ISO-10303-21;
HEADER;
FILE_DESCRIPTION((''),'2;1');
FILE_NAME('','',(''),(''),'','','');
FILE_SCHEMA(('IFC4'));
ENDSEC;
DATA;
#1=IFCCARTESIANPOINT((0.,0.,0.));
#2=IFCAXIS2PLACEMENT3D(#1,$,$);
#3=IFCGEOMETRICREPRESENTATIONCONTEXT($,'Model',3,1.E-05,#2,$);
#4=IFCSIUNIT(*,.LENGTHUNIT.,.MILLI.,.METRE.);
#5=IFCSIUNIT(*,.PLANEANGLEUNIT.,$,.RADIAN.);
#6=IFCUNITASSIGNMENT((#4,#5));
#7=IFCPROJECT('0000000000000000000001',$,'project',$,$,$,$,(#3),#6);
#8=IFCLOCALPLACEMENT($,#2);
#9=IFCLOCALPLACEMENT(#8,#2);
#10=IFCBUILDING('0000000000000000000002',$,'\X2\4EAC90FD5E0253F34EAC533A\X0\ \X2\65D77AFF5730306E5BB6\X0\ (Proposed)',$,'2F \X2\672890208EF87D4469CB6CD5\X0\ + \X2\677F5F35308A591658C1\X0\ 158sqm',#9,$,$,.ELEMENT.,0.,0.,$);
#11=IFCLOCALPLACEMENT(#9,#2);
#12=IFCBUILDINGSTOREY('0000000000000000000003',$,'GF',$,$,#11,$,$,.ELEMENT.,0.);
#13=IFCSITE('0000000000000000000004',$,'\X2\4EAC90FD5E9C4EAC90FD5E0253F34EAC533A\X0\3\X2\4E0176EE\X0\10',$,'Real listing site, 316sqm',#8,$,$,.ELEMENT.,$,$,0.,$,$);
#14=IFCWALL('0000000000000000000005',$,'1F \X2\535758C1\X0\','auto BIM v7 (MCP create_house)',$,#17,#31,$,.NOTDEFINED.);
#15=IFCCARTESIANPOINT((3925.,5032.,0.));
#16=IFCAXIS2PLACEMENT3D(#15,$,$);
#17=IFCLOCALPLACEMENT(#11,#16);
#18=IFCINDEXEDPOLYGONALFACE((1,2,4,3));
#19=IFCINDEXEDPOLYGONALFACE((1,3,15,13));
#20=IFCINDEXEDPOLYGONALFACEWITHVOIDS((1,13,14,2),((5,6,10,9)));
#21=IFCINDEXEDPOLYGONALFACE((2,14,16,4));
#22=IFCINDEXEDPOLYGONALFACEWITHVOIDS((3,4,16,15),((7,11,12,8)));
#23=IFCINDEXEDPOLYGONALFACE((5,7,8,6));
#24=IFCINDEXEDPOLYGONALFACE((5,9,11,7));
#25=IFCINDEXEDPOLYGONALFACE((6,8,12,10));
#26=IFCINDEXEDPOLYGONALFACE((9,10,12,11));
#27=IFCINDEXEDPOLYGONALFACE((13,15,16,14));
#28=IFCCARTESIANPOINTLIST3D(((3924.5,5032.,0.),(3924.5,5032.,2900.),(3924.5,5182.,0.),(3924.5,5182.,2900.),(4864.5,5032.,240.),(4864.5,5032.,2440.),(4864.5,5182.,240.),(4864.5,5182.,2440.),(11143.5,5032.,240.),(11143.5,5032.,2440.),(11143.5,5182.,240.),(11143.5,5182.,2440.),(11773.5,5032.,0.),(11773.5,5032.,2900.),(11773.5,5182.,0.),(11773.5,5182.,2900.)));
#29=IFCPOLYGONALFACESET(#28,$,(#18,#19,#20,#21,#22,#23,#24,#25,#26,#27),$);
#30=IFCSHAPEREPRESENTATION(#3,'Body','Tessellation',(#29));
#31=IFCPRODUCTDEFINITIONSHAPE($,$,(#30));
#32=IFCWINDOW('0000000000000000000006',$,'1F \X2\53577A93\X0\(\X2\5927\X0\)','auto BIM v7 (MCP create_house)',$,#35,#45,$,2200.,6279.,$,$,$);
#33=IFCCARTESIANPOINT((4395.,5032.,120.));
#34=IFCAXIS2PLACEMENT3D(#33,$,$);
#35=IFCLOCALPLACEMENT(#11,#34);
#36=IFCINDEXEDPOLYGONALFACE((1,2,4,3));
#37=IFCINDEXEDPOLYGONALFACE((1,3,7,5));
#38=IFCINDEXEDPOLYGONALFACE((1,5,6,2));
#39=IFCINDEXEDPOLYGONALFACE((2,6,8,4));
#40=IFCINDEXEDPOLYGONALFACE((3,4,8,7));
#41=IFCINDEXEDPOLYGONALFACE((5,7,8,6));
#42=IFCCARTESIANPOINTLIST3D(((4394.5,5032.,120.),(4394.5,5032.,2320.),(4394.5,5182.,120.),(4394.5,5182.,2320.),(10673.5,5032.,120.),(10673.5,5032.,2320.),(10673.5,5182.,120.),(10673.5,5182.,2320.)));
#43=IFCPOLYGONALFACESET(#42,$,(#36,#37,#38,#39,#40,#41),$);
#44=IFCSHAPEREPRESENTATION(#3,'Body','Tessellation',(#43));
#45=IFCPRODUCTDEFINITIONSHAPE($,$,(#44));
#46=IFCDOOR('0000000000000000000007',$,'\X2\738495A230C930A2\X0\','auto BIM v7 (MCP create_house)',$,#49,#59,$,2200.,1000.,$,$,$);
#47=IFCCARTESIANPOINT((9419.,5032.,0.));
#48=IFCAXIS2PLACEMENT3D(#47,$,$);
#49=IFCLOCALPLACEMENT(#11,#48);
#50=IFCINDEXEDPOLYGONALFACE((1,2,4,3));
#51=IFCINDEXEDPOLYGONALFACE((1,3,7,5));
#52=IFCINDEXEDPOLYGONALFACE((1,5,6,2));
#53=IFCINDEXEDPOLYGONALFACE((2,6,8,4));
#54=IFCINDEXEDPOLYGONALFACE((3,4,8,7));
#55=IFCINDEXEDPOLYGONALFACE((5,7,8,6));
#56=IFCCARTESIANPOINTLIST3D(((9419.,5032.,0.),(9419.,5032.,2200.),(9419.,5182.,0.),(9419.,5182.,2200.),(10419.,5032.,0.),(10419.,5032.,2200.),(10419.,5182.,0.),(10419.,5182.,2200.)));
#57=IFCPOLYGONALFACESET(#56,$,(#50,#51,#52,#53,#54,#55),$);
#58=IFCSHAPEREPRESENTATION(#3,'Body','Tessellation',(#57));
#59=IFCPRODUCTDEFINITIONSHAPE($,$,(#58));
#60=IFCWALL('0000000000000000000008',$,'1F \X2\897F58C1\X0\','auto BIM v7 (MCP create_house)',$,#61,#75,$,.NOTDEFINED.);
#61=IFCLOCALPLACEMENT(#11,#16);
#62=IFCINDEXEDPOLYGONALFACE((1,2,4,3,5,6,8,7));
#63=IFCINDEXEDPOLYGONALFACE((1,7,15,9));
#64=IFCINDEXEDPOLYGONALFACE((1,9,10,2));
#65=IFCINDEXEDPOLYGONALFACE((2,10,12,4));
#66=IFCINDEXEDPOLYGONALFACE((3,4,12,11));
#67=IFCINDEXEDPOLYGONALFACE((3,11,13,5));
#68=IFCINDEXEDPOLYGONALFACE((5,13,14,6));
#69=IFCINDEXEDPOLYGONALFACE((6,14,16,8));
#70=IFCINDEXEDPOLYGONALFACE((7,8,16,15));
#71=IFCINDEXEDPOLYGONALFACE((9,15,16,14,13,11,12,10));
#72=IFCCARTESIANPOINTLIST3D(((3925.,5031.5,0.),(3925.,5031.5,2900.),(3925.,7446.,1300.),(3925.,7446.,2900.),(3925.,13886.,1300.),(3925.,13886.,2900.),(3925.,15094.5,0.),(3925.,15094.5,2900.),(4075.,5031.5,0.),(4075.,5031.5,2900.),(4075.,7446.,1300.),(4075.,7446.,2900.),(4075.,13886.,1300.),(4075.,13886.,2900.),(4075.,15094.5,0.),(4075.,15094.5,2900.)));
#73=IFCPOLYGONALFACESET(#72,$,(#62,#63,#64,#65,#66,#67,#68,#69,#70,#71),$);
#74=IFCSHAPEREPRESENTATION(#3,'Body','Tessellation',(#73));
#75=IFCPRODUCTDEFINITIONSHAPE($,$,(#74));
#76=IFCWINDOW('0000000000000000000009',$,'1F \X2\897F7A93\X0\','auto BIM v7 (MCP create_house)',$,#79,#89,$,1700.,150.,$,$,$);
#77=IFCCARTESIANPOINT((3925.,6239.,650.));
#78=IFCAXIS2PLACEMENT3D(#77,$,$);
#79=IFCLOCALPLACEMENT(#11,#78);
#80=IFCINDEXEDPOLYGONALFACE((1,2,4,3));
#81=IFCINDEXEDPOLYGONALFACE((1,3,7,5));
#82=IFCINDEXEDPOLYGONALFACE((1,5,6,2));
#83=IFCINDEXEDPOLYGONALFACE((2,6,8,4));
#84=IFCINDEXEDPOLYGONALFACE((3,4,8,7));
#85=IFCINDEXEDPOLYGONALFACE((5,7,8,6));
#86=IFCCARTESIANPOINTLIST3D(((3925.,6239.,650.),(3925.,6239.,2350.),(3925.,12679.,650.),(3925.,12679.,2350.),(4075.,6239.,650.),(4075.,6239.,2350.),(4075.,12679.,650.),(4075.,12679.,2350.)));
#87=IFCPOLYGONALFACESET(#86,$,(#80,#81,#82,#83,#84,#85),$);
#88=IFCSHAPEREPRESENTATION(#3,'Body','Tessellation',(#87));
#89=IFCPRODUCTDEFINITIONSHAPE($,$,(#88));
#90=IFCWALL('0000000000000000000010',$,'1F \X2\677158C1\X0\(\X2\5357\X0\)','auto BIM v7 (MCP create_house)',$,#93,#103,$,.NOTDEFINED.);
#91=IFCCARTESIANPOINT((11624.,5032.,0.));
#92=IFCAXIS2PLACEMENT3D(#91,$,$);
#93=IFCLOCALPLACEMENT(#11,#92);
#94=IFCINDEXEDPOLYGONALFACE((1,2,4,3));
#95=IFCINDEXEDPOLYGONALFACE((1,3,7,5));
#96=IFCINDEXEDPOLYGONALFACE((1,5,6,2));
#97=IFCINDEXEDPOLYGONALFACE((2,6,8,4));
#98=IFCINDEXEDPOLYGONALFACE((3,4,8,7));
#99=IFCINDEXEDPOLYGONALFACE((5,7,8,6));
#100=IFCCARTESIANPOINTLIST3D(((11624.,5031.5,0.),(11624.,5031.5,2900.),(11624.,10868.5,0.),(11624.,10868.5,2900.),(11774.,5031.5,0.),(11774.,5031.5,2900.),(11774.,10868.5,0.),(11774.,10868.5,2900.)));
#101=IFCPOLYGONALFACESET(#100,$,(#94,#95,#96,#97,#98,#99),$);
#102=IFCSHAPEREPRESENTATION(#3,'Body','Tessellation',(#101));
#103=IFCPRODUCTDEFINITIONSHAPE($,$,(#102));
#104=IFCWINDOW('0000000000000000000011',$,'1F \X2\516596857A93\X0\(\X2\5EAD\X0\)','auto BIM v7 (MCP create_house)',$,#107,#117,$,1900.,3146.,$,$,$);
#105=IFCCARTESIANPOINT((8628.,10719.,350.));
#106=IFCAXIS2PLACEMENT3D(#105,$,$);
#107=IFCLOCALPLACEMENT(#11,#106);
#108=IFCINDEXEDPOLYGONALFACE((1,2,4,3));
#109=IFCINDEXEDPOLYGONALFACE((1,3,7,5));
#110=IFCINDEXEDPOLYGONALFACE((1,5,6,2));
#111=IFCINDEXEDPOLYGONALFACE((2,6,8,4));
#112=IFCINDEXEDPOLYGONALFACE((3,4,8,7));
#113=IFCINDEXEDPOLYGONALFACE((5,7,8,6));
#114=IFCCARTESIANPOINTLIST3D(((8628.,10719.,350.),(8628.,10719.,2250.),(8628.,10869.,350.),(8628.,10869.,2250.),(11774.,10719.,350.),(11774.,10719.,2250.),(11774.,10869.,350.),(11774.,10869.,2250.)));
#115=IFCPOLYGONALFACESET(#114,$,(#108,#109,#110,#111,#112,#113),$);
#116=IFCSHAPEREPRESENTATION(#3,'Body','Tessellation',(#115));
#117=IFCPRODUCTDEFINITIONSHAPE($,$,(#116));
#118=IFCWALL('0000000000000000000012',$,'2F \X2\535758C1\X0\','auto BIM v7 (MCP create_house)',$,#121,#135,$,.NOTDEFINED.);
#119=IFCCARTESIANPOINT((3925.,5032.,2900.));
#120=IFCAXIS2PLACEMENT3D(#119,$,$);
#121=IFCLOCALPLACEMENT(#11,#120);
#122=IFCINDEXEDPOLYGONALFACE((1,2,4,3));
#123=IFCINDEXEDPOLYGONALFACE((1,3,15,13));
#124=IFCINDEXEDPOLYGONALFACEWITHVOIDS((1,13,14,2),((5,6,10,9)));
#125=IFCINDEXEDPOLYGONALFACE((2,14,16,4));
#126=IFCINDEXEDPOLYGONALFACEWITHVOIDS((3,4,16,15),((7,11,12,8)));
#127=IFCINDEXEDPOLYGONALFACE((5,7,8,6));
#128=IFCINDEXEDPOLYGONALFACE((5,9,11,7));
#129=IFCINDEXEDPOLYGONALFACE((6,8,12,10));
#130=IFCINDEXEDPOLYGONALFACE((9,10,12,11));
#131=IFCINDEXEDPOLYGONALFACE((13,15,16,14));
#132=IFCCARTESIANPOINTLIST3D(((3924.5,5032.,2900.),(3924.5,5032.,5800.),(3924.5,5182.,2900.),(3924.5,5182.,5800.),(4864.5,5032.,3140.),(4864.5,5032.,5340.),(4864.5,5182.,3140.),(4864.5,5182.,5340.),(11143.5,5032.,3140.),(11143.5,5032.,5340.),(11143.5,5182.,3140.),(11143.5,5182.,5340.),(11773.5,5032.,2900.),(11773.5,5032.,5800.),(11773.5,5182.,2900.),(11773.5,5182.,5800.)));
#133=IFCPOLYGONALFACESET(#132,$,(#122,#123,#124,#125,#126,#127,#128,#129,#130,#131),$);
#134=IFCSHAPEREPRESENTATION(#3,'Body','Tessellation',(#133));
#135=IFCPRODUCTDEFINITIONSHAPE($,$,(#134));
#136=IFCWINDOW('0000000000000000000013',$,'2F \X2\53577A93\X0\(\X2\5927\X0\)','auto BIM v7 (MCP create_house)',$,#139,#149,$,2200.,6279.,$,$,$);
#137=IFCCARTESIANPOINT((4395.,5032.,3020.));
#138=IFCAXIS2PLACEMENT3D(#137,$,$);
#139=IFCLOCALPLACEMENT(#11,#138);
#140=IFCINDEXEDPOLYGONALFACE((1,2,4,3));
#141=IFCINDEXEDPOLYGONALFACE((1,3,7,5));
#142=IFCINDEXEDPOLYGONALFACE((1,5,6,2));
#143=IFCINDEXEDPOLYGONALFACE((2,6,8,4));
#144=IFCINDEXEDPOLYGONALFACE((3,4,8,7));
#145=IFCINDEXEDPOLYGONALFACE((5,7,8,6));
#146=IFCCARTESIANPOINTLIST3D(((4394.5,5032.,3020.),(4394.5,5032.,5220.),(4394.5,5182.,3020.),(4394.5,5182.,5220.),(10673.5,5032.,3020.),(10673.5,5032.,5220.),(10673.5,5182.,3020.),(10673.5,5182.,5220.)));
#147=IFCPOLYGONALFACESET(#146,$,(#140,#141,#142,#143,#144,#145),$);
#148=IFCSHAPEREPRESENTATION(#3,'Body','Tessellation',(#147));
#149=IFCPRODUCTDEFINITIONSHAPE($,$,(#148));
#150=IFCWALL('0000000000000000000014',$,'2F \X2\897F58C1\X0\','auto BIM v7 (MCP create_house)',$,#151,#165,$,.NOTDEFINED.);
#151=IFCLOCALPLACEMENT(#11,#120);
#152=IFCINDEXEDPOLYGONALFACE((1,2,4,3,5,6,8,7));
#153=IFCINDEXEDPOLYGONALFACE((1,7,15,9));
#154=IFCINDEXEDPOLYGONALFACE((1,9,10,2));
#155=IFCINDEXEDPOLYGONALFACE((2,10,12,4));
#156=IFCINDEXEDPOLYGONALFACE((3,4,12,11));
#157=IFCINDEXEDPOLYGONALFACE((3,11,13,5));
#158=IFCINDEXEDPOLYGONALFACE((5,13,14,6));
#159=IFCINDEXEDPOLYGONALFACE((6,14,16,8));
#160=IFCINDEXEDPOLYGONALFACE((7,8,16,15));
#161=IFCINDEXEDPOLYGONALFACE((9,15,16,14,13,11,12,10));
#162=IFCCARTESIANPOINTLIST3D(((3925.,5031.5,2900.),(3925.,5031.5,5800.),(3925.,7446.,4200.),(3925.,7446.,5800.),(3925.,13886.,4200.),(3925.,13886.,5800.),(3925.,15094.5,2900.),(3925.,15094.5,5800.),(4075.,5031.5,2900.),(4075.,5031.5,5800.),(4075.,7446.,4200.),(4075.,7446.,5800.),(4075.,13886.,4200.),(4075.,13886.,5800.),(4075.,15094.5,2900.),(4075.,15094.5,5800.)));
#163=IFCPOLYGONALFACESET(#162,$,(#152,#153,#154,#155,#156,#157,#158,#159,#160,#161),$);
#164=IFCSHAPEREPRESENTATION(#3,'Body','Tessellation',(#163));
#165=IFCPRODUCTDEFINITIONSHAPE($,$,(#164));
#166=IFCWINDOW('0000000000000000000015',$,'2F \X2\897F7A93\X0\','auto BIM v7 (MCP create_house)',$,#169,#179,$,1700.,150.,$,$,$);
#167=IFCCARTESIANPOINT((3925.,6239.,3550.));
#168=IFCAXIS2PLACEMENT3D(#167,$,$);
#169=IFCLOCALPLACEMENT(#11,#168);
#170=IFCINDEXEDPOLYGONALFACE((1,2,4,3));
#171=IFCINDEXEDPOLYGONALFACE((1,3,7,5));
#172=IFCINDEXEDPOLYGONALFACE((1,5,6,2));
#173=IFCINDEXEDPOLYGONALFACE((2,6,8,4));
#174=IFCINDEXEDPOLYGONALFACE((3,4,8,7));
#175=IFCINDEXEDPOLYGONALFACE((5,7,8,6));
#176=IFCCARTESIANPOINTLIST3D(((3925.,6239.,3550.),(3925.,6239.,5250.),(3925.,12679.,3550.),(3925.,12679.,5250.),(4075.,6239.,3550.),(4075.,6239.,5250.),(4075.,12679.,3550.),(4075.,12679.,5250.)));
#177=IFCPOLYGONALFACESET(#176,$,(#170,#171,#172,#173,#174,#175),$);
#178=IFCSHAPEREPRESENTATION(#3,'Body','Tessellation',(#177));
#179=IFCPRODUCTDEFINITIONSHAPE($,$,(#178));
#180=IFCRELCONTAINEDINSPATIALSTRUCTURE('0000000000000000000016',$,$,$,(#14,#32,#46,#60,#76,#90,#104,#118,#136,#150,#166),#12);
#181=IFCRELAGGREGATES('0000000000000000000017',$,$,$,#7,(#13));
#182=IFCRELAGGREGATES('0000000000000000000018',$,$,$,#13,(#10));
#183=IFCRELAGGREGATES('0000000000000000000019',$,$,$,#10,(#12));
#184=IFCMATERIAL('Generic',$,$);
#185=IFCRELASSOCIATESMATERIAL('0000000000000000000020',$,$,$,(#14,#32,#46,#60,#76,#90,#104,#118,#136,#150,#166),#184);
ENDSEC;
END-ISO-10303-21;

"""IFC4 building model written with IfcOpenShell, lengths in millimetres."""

from ifc_helpers import new_model, si_unit, frame, frame_2d, origin, place, context, project, spatial, rectangle, extrude, material, element, fill, save


model = new_model("IFC4")

# Units and contexts
model_context = context("Model", 3, precision=1e-05, world=origin())
ifc_project = project(units=[si_unit("LENGTHUNIT", "METRE", prefix="MILLI"), si_unit("PLANEANGLEUNIT", "RADIAN")], contexts=[model_context])

# Site, building, storey
site_placement = place(None, origin())
site = spatial("IfcSite", under=ifc_project, at=site_placement, Name="京都府京都市右京区3丁目10", ObjectType="Real listing site, 316sqm", CompositionType="ELEMENT", RefElevation=0.0)
building_placement = place(site_placement, origin())
building = spatial("IfcBuilding", under=site, at=building_placement, Name="京都市右京区 旗竿地の家 (Proposed)", ObjectType="2F 木造軸組構法 + 板張り外壁 158sqm", CompositionType="ELEMENT", ElevationOfRefHeight=0.0, ElevationOfTerrain=0.0)
storey_placement = place(building_placement, origin())
storey = spatial("IfcBuildingStorey", under=building, at=storey_placement, Name="GF", CompositionType="ELEMENT", Elevation=0.0)

# Shared definitions
ifc_material = material(Name="Generic")

# Wall, openings, window, door
wall_1_placement = place(storey_placement, frame((3925.0, 5032.0, 0.0)))
wall_1 = element("IfcWall", 1, at=wall_1_placement, inside=storey, material=ifc_material, Name="1F 南壁", Description="auto BIM v7 (MCP create_house)", PredefinedType="NOTDEFINED", context=model_context, shape_type="SweptSolid", body=[
    extrude(rectangle(XDim=7849.0, YDim=150.0, at=frame_2d((3924.0, 75.0))), frame((3925.0, 5032.0, 0.0)), (0.0, 0.0, 1.0), 2900.0),
])
opening_1_placement = place(storey_placement, frame((4395.0, 5032.0, 120.0)))
opening_1 = element("IfcOpeningElement", 2, at=opening_1_placement, cuts=wall_1, PredefinedType="NOTDEFINED", context=model_context, shape_type="SweptSolid", body=[
    extrude(rectangle(XDim=6279.0, YDim=150.0, at=frame_2d((3139.0, 75.0))), frame((4395.0, 5032.0, 120.0)), (0.0, 0.0, 1.0), 2200.0),
])
opening_2_placement = place(storey_placement, frame((9419.0, 5032.0, 0.0)))
opening_2 = element("IfcOpeningElement", 3, at=opening_2_placement, cuts=wall_1, PredefinedType="NOTDEFINED", context=model_context, shape_type="SweptSolid", body=[
    extrude(rectangle(XDim=1000.0, YDim=150.0, at=frame_2d((500.0, 75.0))), frame((9419.0, 5032.0, 0.0)), (0.0, 0.0, 1.0), 2200.0),
])
window_1_placement = place(storey_placement, frame((4395.0, 5032.0, 120.0)))
window_1 = element("IfcWindow", 4, at=window_1_placement, inside=storey, material=ifc_material, Name="1F 南窓(大)", Description="auto BIM v7 (MCP create_house)", OverallHeight=2200.0, OverallWidth=6279.0, context=model_context, shape_type="SweptSolid", body=[
    extrude(rectangle(XDim=6279.0, YDim=150.0, at=frame_2d((3139.0, 75.0))), frame((4395.0, 5032.0, 120.0)), (0.0, 0.0, 1.0), 2200.0),
])
fill(opening_1, window_1)
door_placement = place(storey_placement, frame((9419.0, 5032.0, 0.0)))
door = element("IfcDoor", 5, at=door_placement, inside=storey, material=ifc_material, Name="玄関ドア", Description="auto BIM v7 (MCP create_house)", OverallHeight=2200.0, OverallWidth=1000.0, context=model_context, shape_type="SweptSolid", body=[
    extrude(rectangle(XDim=1000.0, YDim=150.0, at=frame_2d((500.0, 75.0))), frame((9419.0, 5032.0, 0.0)), (0.0, 0.0, 1.0), 2200.0),
])
fill(opening_2, door)

# Walls, openings, windows
wall_2_placement = place(storey_placement, frame((3925.0, 5032.0, 0.0)))
wall_2 = element("IfcWall", 6, at=wall_2_placement, inside=storey, material=ifc_material, Name="1F 西壁", Description="auto BIM v7 (MCP create_house)", PredefinedType="NOTDEFINED", context=model_context, shape_type="SweptSolid", body=[
    extrude(rectangle(XDim=150.0, YDim=10063.0, at=frame_2d((75.0, 5031.0))), frame((3925.0, 5032.0, 0.0)), (0.0, 0.0, 1.0), 2900.0),
])
opening_3_placement = place(storey_placement, frame((3925.0, 6239.0, 650.0)))
opening_3 = element("IfcOpeningElement", 7, at=opening_3_placement, cuts=wall_2, PredefinedType="NOTDEFINED", context=model_context, shape_type="SweptSolid", body=[
    extrude(rectangle(XDim=150.0, YDim=6440.0, at=frame_2d((75.0, 3220.0))), frame((3925.0, 6239.0, 650.0)), (0.0, 0.0, 1.0), 1700.0),
])
window_2_placement = place(storey_placement, frame((3925.0, 6239.0, 650.0)))
window_2 = element("IfcWindow", 8, at=window_2_placement, inside=storey, material=ifc_material, Name="1F 西窓", Description="auto BIM v7 (MCP create_house)", OverallHeight=1700.0, OverallWidth=150.0, context=model_context, shape_type="SweptSolid", body=[
    extrude(rectangle(XDim=150.0, YDim=6440.0, at=frame_2d((75.0, 3220.0))), frame((3925.0, 6239.0, 650.0)), (0.0, 0.0, 1.0), 1700.0),
])
fill(opening_3, window_2)
wall_3_placement = place(storey_placement, frame((11624.0, 5032.0, 0.0)))
wall_3 = element("IfcWall", 9, at=wall_3_placement, inside=storey, material=ifc_material, Name="1F 東壁(南)", Description="auto BIM v7 (MCP create_house)", PredefinedType="NOTDEFINED", context=model_context, shape_type="SweptSolid", body=[
    extrude(rectangle(XDim=150.0, YDim=5837.0, at=frame_2d((75.0, 2918.0))), frame((11624.0, 5032.0, 0.0)), (0.0, 0.0, 1.0), 2900.0),
])
opening_4_placement = place(storey_placement, frame((8628.0, 10719.0, 350.0)))
opening_4 = element("IfcOpeningElement", 10, at=opening_4_placement, cuts=wall_3, PredefinedType="NOTDEFINED", context=model_context, shape_type="SweptSolid", body=[
    extrude(rectangle(XDim=3146.0, YDim=150.0, at=frame_2d((1573.0, 75.0))), frame((8628.0, 10719.0, 350.0)), (0.0, 0.0, 1.0), 1900.0),
])
window_3_placement = place(storey_placement, frame((8628.0, 10719.0, 350.0)))
window_3 = element("IfcWindow", 11, at=window_3_placement, inside=storey, material=ifc_material, Name="1F 入隅窓(庭)", Description="auto BIM v7 (MCP create_house)", OverallHeight=1900.0, OverallWidth=3146.0, context=model_context, shape_type="SweptSolid", body=[
    extrude(rectangle(XDim=3146.0, YDim=150.0, at=frame_2d((1573.0, 75.0))), frame((8628.0, 10719.0, 350.0)), (0.0, 0.0, 1.0), 1900.0),
])
fill(opening_4, window_3)

# Walls, openings, windows
wall_4_placement = place(storey_placement, frame((3925.0, 5032.0, 2900.0)))
wall_4 = element("IfcWall", 12, at=wall_4_placement, inside=storey, material=ifc_material, Name="2F 南壁", Description="auto BIM v7 (MCP create_house)", PredefinedType="NOTDEFINED", context=model_context, shape_type="SweptSolid", body=[
    extrude(rectangle(XDim=7849.0, YDim=150.0, at=frame_2d((3924.0, 75.0))), frame((3925.0, 5032.0, 2900.0)), (0.0, 0.0, 1.0), 2900.0),
])
opening_5_placement = place(storey_placement, frame((4395.0, 5032.0, 3020.0)))
opening_5 = element("IfcOpeningElement", 13, at=opening_5_placement, cuts=wall_4, PredefinedType="NOTDEFINED", context=model_context, shape_type="SweptSolid", body=[
    extrude(rectangle(XDim=6279.0, YDim=150.0, at=frame_2d((3139.0, 75.0))), frame((4395.0, 5032.0, 3020.0)), (0.0, 0.0, 1.0), 2200.0),
])
window_4_placement = place(storey_placement, frame((4395.0, 5032.0, 3020.0)))
window_4 = element("IfcWindow", 14, at=window_4_placement, inside=storey, material=ifc_material, Name="2F 南窓(大)", Description="auto BIM v7 (MCP create_house)", OverallHeight=2200.0, OverallWidth=6279.0, context=model_context, shape_type="SweptSolid", body=[
    extrude(rectangle(XDim=6279.0, YDim=150.0, at=frame_2d((3139.0, 75.0))), frame((4395.0, 5032.0, 3020.0)), (0.0, 0.0, 1.0), 2200.0),
])
fill(opening_5, window_4)
wall_5_placement = place(storey_placement, frame((3925.0, 5032.0, 2900.0)))
wall_5 = element("IfcWall", 15, at=wall_5_placement, inside=storey, material=ifc_material, Name="2F 西壁", Description="auto BIM v7 (MCP create_house)", PredefinedType="NOTDEFINED", context=model_context, shape_type="SweptSolid", body=[
    extrude(rectangle(XDim=150.0, YDim=10063.0, at=frame_2d((75.0, 5031.0))), frame((3925.0, 5032.0, 2900.0)), (0.0, 0.0, 1.0), 2900.0),
])
opening_6_placement = place(storey_placement, frame((3925.0, 6239.0, 3550.0)))
opening_6 = element("IfcOpeningElement", 16, at=opening_6_placement, cuts=wall_5, PredefinedType="NOTDEFINED", context=model_context, shape_type="SweptSolid", body=[
    extrude(rectangle(XDim=150.0, YDim=6440.0, at=frame_2d((75.0, 3220.0))), frame((3925.0, 6239.0, 3550.0)), (0.0, 0.0, 1.0), 1700.0),
])
window_5_placement = place(storey_placement, frame((3925.0, 6239.0, 3550.0)))
window_5 = element("IfcWindow", 17, at=window_5_placement, inside=storey, material=ifc_material, Name="2F 西窓", Description="auto BIM v7 (MCP create_house)", OverallHeight=1700.0, OverallWidth=150.0, context=model_context, shape_type="SweptSolid", body=[
    extrude(rectangle(XDim=150.0, YDim=6440.0, at=frame_2d((75.0, 3220.0))), frame((3925.0, 6239.0, 3550.0)), (0.0, 0.0, 1.0), 1700.0),
])
fill(opening_6, window_5)

save(model, "model.ifc")
